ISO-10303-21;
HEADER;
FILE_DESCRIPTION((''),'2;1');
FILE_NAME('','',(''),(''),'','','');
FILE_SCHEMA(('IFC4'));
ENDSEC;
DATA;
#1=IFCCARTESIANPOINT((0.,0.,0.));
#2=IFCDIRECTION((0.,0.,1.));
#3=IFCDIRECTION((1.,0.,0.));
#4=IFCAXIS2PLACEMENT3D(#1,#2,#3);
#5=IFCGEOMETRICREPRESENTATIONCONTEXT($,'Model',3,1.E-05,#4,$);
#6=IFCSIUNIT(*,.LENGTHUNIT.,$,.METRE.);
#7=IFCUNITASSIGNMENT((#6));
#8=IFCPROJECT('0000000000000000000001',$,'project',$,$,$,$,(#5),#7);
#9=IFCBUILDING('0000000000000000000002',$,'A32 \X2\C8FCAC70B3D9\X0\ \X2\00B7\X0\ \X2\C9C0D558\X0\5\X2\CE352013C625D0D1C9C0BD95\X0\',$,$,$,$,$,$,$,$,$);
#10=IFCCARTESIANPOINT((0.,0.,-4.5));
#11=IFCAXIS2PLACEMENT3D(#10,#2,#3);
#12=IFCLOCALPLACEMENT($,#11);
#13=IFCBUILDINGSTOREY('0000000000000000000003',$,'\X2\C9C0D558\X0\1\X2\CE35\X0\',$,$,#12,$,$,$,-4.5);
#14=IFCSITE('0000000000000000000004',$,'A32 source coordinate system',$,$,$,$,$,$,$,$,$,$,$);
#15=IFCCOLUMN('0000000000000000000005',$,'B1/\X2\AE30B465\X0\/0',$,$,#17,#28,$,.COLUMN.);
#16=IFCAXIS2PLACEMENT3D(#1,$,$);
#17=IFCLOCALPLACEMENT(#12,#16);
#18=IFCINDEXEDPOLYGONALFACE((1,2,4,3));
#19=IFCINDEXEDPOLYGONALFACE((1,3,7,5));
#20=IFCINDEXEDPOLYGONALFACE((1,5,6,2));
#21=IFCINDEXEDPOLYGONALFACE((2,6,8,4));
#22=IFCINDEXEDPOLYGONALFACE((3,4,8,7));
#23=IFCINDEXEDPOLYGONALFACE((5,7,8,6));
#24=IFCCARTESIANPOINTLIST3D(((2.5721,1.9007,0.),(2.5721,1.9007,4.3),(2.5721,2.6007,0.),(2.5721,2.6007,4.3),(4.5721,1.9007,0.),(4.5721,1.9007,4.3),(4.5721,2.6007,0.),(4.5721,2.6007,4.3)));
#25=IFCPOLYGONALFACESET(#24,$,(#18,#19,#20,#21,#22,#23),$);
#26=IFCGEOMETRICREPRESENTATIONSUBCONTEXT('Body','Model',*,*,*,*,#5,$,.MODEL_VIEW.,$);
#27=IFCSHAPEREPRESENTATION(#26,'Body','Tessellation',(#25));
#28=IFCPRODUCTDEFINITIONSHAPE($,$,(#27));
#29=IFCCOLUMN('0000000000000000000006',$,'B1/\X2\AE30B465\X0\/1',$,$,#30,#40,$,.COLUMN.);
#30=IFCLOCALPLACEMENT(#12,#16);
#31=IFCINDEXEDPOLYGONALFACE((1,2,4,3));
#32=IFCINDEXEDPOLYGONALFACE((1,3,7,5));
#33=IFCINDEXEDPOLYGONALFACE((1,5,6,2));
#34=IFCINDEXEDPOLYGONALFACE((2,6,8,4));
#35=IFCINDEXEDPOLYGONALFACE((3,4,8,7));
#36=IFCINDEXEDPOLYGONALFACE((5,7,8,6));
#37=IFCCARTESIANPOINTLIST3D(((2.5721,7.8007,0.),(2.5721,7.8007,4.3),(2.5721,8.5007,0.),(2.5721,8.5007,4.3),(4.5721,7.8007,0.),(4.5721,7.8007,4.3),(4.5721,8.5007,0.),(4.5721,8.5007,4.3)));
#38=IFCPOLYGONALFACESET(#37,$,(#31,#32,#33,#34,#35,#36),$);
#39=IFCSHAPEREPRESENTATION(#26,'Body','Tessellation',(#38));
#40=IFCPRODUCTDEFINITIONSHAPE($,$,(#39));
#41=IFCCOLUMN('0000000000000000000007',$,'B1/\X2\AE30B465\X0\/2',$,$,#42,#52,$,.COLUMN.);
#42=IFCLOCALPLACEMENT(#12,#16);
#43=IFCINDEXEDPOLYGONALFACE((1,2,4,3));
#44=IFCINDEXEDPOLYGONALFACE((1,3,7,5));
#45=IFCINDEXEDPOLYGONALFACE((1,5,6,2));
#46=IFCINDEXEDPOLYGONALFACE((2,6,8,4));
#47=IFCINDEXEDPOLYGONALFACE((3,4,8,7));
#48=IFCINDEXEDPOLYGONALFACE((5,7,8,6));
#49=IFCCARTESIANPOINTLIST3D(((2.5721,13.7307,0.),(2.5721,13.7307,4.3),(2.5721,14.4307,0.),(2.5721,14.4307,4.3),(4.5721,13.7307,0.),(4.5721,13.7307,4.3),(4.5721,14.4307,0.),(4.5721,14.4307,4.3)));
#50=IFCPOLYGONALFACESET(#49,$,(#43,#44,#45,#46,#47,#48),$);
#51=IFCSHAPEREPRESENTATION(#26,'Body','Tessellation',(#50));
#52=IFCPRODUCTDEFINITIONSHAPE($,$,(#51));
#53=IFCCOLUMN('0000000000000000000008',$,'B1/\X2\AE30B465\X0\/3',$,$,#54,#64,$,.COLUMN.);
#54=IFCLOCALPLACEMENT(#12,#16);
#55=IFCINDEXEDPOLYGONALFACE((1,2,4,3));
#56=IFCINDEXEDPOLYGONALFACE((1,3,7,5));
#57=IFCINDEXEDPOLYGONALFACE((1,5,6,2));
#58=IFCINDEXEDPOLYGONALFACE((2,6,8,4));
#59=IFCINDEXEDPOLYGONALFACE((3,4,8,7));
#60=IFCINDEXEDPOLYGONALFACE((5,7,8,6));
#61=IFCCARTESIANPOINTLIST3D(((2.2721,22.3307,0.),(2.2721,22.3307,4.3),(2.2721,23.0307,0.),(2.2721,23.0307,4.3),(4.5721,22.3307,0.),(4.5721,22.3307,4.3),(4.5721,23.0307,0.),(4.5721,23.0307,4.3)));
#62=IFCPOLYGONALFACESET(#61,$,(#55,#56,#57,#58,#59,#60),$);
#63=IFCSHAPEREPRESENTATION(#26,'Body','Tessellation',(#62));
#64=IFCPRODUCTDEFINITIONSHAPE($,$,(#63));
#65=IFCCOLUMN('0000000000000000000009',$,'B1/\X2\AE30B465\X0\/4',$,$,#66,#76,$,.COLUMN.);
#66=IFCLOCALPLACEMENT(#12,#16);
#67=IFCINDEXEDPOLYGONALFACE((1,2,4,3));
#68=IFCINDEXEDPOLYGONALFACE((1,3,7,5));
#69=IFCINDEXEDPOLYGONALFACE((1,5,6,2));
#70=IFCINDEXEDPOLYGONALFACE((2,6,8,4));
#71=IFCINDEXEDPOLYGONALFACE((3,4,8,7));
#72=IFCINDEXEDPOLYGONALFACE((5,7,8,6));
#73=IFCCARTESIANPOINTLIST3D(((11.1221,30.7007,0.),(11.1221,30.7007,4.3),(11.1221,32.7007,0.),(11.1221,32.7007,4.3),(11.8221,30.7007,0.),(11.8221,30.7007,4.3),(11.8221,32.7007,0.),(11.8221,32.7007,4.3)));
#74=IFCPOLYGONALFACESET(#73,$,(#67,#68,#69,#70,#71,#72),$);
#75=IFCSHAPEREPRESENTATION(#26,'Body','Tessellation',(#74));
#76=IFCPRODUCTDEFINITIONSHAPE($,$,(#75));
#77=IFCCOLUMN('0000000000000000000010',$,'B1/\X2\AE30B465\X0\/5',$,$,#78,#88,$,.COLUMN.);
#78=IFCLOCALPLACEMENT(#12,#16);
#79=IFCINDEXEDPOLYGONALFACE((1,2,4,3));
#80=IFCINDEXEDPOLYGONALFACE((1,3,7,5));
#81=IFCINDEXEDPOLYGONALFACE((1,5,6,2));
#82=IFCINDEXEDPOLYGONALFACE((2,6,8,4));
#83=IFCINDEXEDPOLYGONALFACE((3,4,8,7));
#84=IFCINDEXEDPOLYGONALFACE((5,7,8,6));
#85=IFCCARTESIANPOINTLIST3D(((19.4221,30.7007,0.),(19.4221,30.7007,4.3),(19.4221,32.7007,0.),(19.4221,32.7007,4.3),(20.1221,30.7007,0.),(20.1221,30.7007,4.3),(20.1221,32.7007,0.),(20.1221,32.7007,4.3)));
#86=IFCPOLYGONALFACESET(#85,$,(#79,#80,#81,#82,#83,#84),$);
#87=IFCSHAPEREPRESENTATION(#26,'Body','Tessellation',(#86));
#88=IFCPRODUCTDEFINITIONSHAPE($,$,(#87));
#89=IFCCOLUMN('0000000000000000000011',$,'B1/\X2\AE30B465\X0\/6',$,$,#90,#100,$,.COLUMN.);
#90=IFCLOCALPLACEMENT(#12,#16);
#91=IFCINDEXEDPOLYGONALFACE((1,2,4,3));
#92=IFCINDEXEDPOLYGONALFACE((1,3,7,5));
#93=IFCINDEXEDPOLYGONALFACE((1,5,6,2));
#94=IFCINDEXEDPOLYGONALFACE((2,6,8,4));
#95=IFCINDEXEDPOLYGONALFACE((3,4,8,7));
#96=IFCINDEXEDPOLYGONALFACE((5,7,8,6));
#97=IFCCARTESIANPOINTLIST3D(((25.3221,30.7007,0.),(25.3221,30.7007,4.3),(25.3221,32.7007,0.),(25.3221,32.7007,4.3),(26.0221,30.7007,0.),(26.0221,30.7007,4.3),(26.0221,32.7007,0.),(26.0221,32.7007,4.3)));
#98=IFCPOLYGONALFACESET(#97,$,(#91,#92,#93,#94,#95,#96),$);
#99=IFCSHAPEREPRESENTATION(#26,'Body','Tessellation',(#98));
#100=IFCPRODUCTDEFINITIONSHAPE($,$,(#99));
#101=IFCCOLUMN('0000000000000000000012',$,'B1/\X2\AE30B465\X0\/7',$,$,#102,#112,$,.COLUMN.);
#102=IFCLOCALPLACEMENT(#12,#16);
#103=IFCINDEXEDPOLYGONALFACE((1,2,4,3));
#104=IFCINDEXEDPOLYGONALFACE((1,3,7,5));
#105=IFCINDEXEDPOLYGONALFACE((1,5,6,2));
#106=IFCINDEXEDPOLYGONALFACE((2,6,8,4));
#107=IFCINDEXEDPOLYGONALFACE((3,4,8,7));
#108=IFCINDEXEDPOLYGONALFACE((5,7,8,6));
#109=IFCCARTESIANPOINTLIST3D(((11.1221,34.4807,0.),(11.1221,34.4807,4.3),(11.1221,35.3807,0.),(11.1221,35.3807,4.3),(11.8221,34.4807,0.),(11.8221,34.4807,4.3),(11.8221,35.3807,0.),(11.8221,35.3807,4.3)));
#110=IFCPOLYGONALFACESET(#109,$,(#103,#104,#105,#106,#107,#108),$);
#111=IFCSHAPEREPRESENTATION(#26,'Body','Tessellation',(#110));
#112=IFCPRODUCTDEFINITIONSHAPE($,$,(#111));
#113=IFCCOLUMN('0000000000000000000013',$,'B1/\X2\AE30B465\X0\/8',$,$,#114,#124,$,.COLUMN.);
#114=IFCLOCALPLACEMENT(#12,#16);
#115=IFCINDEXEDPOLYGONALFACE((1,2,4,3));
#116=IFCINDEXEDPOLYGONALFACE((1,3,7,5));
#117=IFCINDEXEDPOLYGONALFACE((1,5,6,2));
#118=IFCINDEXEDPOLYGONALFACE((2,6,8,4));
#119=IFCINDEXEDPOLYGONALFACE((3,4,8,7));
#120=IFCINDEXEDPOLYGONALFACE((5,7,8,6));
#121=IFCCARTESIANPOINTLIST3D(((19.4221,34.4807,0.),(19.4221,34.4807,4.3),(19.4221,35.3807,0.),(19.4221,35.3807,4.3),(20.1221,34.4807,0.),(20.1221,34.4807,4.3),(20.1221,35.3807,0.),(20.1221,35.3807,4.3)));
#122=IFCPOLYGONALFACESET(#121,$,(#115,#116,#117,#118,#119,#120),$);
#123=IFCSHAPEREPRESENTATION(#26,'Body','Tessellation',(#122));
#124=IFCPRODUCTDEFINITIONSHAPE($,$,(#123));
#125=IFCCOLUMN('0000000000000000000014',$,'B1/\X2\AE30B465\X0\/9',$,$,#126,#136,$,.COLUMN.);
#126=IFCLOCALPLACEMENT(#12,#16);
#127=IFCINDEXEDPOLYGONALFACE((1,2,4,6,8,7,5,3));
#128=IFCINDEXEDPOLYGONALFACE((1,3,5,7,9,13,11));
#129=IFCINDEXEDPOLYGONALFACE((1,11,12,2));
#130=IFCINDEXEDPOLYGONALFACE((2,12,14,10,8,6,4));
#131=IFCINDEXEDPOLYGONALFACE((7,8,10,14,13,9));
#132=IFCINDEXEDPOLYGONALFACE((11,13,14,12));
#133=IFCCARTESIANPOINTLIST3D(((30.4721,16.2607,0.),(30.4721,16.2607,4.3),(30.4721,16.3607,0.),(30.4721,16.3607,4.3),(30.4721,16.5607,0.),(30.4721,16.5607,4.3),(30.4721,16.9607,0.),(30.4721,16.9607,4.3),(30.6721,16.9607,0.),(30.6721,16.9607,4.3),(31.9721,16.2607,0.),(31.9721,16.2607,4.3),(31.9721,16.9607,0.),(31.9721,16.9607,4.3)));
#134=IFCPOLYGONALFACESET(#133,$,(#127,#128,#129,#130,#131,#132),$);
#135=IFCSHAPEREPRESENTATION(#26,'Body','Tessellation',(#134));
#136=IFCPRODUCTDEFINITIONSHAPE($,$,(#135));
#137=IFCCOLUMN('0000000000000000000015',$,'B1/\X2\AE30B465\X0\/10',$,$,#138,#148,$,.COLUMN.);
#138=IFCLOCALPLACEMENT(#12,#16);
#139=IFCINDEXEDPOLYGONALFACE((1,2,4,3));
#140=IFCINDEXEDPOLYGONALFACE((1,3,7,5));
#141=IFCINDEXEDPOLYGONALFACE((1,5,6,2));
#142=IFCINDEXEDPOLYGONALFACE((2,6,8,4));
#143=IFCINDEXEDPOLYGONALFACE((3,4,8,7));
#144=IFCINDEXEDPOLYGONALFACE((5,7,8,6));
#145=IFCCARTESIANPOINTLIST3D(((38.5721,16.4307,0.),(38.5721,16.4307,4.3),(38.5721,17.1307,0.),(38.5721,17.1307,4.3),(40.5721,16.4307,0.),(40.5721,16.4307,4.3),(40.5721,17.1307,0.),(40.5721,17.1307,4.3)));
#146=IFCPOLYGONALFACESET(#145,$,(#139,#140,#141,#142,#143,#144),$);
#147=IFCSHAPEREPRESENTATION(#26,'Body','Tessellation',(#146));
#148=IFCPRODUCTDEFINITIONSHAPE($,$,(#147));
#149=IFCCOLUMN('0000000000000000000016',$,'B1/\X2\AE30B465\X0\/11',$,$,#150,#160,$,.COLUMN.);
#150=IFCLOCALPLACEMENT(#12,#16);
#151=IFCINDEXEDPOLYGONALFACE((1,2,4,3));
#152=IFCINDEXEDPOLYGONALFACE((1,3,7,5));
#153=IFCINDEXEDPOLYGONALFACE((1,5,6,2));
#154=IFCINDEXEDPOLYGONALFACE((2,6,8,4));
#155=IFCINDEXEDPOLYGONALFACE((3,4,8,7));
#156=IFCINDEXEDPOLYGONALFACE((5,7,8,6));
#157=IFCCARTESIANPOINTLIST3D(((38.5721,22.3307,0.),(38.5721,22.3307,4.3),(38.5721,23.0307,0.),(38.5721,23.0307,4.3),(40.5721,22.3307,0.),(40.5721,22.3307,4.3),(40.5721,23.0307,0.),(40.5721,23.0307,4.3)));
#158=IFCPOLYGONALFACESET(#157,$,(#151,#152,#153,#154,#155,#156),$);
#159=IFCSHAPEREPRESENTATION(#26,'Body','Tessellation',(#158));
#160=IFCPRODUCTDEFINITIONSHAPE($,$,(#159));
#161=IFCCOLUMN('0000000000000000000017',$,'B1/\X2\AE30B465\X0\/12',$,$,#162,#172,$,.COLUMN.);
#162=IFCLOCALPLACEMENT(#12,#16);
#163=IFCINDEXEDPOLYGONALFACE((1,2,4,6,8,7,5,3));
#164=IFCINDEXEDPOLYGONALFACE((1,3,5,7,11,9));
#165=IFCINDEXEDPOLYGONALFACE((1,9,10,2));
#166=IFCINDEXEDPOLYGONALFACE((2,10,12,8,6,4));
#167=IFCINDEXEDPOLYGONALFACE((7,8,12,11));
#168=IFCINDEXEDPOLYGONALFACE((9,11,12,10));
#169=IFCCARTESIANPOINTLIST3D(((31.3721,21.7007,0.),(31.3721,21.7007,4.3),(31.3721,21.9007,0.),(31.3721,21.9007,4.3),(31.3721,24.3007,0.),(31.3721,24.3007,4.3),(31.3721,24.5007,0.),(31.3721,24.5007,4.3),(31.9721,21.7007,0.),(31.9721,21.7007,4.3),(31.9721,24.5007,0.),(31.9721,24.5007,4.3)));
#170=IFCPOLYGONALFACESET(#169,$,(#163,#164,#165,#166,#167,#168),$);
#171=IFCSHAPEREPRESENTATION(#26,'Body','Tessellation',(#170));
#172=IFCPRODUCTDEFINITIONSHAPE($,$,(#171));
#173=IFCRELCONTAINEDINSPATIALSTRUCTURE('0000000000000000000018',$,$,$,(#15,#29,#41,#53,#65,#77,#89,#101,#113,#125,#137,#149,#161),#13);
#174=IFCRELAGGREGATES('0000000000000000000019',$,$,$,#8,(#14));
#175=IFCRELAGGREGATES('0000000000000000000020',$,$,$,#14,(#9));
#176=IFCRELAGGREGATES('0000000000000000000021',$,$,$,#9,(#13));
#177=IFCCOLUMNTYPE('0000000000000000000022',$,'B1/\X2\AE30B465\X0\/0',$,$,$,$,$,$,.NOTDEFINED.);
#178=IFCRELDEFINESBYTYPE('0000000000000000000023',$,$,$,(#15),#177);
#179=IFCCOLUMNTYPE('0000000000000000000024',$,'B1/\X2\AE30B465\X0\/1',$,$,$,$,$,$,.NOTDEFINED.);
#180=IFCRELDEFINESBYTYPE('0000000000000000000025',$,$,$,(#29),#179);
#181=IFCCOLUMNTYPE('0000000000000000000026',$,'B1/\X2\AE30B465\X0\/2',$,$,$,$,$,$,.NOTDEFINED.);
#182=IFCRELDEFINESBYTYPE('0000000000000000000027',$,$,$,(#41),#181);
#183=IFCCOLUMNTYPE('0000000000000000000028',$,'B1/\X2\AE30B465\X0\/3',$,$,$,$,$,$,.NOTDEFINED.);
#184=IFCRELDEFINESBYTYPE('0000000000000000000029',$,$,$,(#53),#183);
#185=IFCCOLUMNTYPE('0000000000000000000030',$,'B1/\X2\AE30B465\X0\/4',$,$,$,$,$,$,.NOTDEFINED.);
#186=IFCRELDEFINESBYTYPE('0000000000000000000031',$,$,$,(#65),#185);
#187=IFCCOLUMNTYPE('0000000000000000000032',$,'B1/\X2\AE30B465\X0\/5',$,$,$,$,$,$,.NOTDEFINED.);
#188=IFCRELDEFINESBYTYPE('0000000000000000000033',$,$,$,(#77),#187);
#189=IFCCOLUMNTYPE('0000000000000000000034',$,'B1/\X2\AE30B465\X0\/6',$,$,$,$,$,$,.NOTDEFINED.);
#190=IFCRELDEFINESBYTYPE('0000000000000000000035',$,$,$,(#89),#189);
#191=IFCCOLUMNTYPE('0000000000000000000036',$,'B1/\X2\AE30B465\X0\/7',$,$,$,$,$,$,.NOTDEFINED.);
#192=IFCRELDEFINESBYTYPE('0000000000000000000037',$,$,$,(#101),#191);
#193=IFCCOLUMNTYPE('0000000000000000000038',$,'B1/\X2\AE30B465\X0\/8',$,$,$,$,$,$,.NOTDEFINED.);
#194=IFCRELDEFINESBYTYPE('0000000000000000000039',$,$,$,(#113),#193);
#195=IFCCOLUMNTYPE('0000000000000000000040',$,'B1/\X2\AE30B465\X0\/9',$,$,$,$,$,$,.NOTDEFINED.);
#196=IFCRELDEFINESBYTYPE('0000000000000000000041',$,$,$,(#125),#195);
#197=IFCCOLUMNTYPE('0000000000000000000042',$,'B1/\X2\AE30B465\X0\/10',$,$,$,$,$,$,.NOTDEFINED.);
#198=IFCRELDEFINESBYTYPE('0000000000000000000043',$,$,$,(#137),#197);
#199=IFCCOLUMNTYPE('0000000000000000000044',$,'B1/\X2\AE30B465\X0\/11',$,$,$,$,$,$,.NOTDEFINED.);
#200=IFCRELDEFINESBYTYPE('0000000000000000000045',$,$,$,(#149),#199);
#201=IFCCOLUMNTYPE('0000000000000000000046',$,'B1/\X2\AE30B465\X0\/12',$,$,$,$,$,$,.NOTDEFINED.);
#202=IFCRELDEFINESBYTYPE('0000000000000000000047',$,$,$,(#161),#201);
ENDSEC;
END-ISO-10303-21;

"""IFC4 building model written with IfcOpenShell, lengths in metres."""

from ifc_helpers import new_model, si_unit, frame, origin, origin_with_axes, place, context, subcontext, project, spatial, polyline, outline, extrude, source, transform, mapped, type_object, type_shapes, element, save


model = new_model("IFC4")

# Units and contexts
model_context = context("Model", 3, precision=1e-05, world=origin_with_axes())
body_context = subcontext(model_context, "Body", "Model", "MODEL_VIEW")
ifc_project = project(units=[si_unit("LENGTHUNIT", "METRE")], contexts=[model_context])

# Site, building, storey
site = spatial("IfcSite", under=ifc_project, Name="A32 source coordinate system")
building = spatial("IfcBuilding", under=site, Name="A32 주거동 · 지하5층–옥탑지붕")
storey_placement = place(None, frame((0.0, 0.0, -4.5), z_axis=(0.0, 0.0, 1.0), x_axis=(1.0, 0.0, 0.0)))
storey = spatial("IfcBuildingStorey", under=building, at=storey_placement, Name="지하1층", Elevation=-4.5)

# Columns
column_type_1 = type_object("IfcColumnType", Name="B1/기둥/0", PredefinedType="NOTDEFINED")
shared_shape_1 = source(origin(), body_context, "Body", "SweptSolid", [
    extrude(outline(polyline([(4.5721, 2.6007), (4.5721, 1.9007), (2.5721, 1.9007), (2.5721, 2.6007), (4.5721, 2.6007)])), origin(), (0.0, 0.0, 1.0), 4.3),
])
type_shapes(column_type_1, [shared_shape_1])
column_1_placement = place(storey_placement, origin_with_axes())
element("IfcColumn", 1, at=column_1_placement, inside=storey, type_object=column_type_1, Name="B1/기둥/0", PredefinedType="COLUMN", context=body_context, shape_type="MappedRepresentation", body=[
    mapped(shared_shape_1, transform((0.0, 0.0, 0.0), scale=1.0)),
])
column_type_2 = type_object("IfcColumnType", Name="B1/기둥/1", PredefinedType="NOTDEFINED")
shared_shape_2 = source(origin(), body_context, "Body", "SweptSolid", [
    extrude(outline(polyline([(4.5721, 7.8007), (2.5721, 7.8007), (2.5721, 8.5007), (4.5721, 8.5007), (4.5721, 7.8007)])), origin(), (0.0, 0.0, 1.0), 4.3),
])
type_shapes(column_type_2, [shared_shape_2])
column_2_placement = place(storey_placement, origin_with_axes())
element("IfcColumn", 2, at=column_2_placement, inside=storey, type_object=column_type_2, Name="B1/기둥/1", PredefinedType="COLUMN", context=body_context, shape_type="MappedRepresentation", body=[
    mapped(shared_shape_2, transform((0.0, 0.0, 0.0), scale=1.0)),
])
column_type_3 = type_object("IfcColumnType", Name="B1/기둥/2", PredefinedType="NOTDEFINED")
shared_shape_3 = source(origin(), body_context, "Body", "SweptSolid", [
    extrude(outline(polyline([(4.5721, 14.4307), (4.5721, 13.7307), (2.5721, 13.7307), (2.5721, 14.4307), (4.5721, 14.4307)])), origin(), (0.0, 0.0, 1.0), 4.3),
])
type_shapes(column_type_3, [shared_shape_3])
column_3_placement = place(storey_placement, origin_with_axes())
element("IfcColumn", 3, at=column_3_placement, inside=storey, type_object=column_type_3, Name="B1/기둥/2", PredefinedType="COLUMN", context=body_context, shape_type="MappedRepresentation", body=[
    mapped(shared_shape_3, transform((0.0, 0.0, 0.0), scale=1.0)),
])
column_type_4 = type_object("IfcColumnType", Name="B1/기둥/3", PredefinedType="NOTDEFINED")
shared_shape_4 = source(origin(), body_context, "Body", "SweptSolid", [
    extrude(outline(polyline([(4.5721, 23.0307), (4.5721, 22.3307), (2.2721, 22.3307), (2.2721, 23.0307), (4.5721, 23.0307)])), origin(), (0.0, 0.0, 1.0), 4.3),
])
type_shapes(column_type_4, [shared_shape_4])
column_4_placement = place(storey_placement, origin_with_axes())
element("IfcColumn", 4, at=column_4_placement, inside=storey, type_object=column_type_4, Name="B1/기둥/3", PredefinedType="COLUMN", context=body_context, shape_type="MappedRepresentation", body=[
    mapped(shared_shape_4, transform((0.0, 0.0, 0.0), scale=1.0)),
])
column_type_5 = type_object("IfcColumnType", Name="B1/기둥/4", PredefinedType="NOTDEFINED")
shared_shape_5 = source(origin(), body_context, "Body", "SweptSolid", [
    extrude(outline(polyline([(11.8221, 32.7007), (11.8221, 30.7007), (11.1221, 30.7007), (11.1221, 32.7007), (11.8221, 32.7007)])), origin(), (0.0, 0.0, 1.0), 4.3),
])
type_shapes(column_type_5, [shared_shape_5])
column_5_placement = place(storey_placement, origin_with_axes())
element("IfcColumn", 5, at=column_5_placement, inside=storey, type_object=column_type_5, Name="B1/기둥/4", PredefinedType="COLUMN", context=body_context, shape_type="MappedRepresentation", body=[
    mapped(shared_shape_5, transform((0.0, 0.0, 0.0), scale=1.0)),
])
column_type_6 = type_object("IfcColumnType", Name="B1/기둥/5", PredefinedType="NOTDEFINED")
shared_shape_6 = source(origin(), body_context, "Body", "SweptSolid", [
    extrude(outline(polyline([(20.1221, 30.7007), (19.4221, 30.7007), (19.4221, 32.7007), (20.1221, 32.7007), (20.1221, 30.7007)])), origin(), (0.0, 0.0, 1.0), 4.3),
])
type_shapes(column_type_6, [shared_shape_6])
column_6_placement = place(storey_placement, origin_with_axes())
element("IfcColumn", 6, at=column_6_placement, inside=storey, type_object=column_type_6, Name="B1/기둥/5", PredefinedType="COLUMN", context=body_context, shape_type="MappedRepresentation", body=[
    mapped(shared_shape_6, transform((0.0, 0.0, 0.0), scale=1.0)),
])
column_type_7 = type_object("IfcColumnType", Name="B1/기둥/6", PredefinedType="NOTDEFINED")
shared_shape_7 = source(origin(), body_context, "Body", "SweptSolid", [
    extrude(outline(polyline([(26.0221, 30.7007), (25.3221, 30.7007), (25.3221, 32.7007), (26.0221, 32.7007), (26.0221, 30.7007)])), origin(), (0.0, 0.0, 1.0), 4.3),
])
type_shapes(column_type_7, [shared_shape_7])
column_7_placement = place(storey_placement, origin_with_axes())
element("IfcColumn", 7, at=column_7_placement, inside=storey, type_object=column_type_7, Name="B1/기둥/6", PredefinedType="COLUMN", context=body_context, shape_type="MappedRepresentation", body=[
    mapped(shared_shape_7, transform((0.0, 0.0, 0.0), scale=1.0)),
])
column_type_8 = type_object("IfcColumnType", Name="B1/기둥/7", PredefinedType="NOTDEFINED")
shared_shape_8 = source(origin(), body_context, "Body", "SweptSolid", [
    extrude(outline(polyline([(11.1221, 34.4807), (11.1221, 35.3807), (11.8221, 35.3807), (11.8221, 34.4807), (11.1221, 34.4807)])), origin(), (0.0, 0.0, 1.0), 4.3),
])
type_shapes(column_type_8, [shared_shape_8])
column_8_placement = place(storey_placement, origin_with_axes())
element("IfcColumn", 8, at=column_8_placement, inside=storey, type_object=column_type_8, Name="B1/기둥/7", PredefinedType="COLUMN", context=body_context, shape_type="MappedRepresentation", body=[
    mapped(shared_shape_8, transform((0.0, 0.0, 0.0), scale=1.0)),
])
column_type_9 = type_object("IfcColumnType", Name="B1/기둥/8", PredefinedType="NOTDEFINED")
shared_shape_9 = source(origin(), body_context, "Body", "SweptSolid", [
    extrude(outline(polyline([(20.1221, 34.4807), (19.4221, 34.4807), (19.4221, 35.3807), (20.1221, 35.3807), (20.1221, 34.4807)])), origin(), (0.0, 0.0, 1.0), 4.3),
])
type_shapes(column_type_9, [shared_shape_9])
column_9_placement = place(storey_placement, origin_with_axes())
element("IfcColumn", 9, at=column_9_placement, inside=storey, type_object=column_type_9, Name="B1/기둥/8", PredefinedType="COLUMN", context=body_context, shape_type="MappedRepresentation", body=[
    mapped(shared_shape_9, transform((0.0, 0.0, 0.0), scale=1.0)),
])
column_type_10 = type_object("IfcColumnType", Name="B1/기둥/9", PredefinedType="NOTDEFINED")
shared_shape_10 = source(origin(), body_context, "Body", "SweptSolid", [
    extrude(outline(polyline([(30.6721, 16.9607), (31.9721, 16.9607), (31.9721, 16.2607), (30.4721, 16.2607), (30.4721, 16.3607), (30.4721, 16.5607), (30.4721, 16.9607), (30.6721, 16.9607)])), origin(), (0.0, 0.0, 1.0), 4.3),
])
type_shapes(column_type_10, [shared_shape_10])
column_10_placement = place(storey_placement, origin_with_axes())
element("IfcColumn", 10, at=column_10_placement, inside=storey, type_object=column_type_10, Name="B1/기둥/9", PredefinedType="COLUMN", context=body_context, shape_type="MappedRepresentation", body=[
    mapped(shared_shape_10, transform((0.0, 0.0, 0.0), scale=1.0)),
])
column_type_11 = type_object("IfcColumnType", Name="B1/기둥/10", PredefinedType="NOTDEFINED")
shared_shape_11 = source(origin(), body_context, "Body", "SweptSolid", [
    extrude(outline(polyline([(40.5721, 16.4307), (38.5721, 16.4307), (38.5721, 17.1307), (40.5721, 17.1307), (40.5721, 16.4307)])), origin(), (0.0, 0.0, 1.0), 4.3),
])
type_shapes(column_type_11, [shared_shape_11])
column_11_placement = place(storey_placement, origin_with_axes())
element("IfcColumn", 11, at=column_11_placement, inside=storey, type_object=column_type_11, Name="B1/기둥/10", PredefinedType="COLUMN", context=body_context, shape_type="MappedRepresentation", body=[
    mapped(shared_shape_11, transform((0.0, 0.0, 0.0), scale=1.0)),
])
column_type_12 = type_object("IfcColumnType", Name="B1/기둥/11", PredefinedType="NOTDEFINED")
shared_shape_12 = source(origin(), body_context, "Body", "SweptSolid", [
    extrude(outline(polyline([(40.5721, 22.3307), (38.5721, 22.3307), (38.5721, 23.0307), (40.5721, 23.0307), (40.5721, 22.3307)])), origin(), (0.0, 0.0, 1.0), 4.3),
])
type_shapes(column_type_12, [shared_shape_12])
column_12_placement = place(storey_placement, origin_with_axes())
element("IfcColumn", 12, at=column_12_placement, inside=storey, type_object=column_type_12, Name="B1/기둥/11", PredefinedType="COLUMN", context=body_context, shape_type="MappedRepresentation", body=[
    mapped(shared_shape_12, transform((0.0, 0.0, 0.0), scale=1.0)),
])
column_type_13 = type_object("IfcColumnType", Name="B1/기둥/12", PredefinedType="NOTDEFINED")
shared_shape_13 = source(origin(), body_context, "Body", "SweptSolid", [
    extrude(outline(polyline([(31.3721, 21.7007), (31.3721, 21.9007), (31.3721, 24.3007), (31.3721, 24.5007), (31.9721, 24.5007), (31.9721, 21.7007), (31.3721, 21.7007)])), origin(), (0.0, 0.0, 1.0), 4.3),
])
type_shapes(column_type_13, [shared_shape_13])
column_13_placement = place(storey_placement, origin_with_axes())
element("IfcColumn", 13, at=column_13_placement, inside=storey, type_object=column_type_13, Name="B1/기둥/12", PredefinedType="COLUMN", context=body_context, shape_type="MappedRepresentation", body=[
    mapped(shared_shape_13, transform((0.0, 0.0, 0.0), scale=1.0)),
])

save(model, "model.ifc")
